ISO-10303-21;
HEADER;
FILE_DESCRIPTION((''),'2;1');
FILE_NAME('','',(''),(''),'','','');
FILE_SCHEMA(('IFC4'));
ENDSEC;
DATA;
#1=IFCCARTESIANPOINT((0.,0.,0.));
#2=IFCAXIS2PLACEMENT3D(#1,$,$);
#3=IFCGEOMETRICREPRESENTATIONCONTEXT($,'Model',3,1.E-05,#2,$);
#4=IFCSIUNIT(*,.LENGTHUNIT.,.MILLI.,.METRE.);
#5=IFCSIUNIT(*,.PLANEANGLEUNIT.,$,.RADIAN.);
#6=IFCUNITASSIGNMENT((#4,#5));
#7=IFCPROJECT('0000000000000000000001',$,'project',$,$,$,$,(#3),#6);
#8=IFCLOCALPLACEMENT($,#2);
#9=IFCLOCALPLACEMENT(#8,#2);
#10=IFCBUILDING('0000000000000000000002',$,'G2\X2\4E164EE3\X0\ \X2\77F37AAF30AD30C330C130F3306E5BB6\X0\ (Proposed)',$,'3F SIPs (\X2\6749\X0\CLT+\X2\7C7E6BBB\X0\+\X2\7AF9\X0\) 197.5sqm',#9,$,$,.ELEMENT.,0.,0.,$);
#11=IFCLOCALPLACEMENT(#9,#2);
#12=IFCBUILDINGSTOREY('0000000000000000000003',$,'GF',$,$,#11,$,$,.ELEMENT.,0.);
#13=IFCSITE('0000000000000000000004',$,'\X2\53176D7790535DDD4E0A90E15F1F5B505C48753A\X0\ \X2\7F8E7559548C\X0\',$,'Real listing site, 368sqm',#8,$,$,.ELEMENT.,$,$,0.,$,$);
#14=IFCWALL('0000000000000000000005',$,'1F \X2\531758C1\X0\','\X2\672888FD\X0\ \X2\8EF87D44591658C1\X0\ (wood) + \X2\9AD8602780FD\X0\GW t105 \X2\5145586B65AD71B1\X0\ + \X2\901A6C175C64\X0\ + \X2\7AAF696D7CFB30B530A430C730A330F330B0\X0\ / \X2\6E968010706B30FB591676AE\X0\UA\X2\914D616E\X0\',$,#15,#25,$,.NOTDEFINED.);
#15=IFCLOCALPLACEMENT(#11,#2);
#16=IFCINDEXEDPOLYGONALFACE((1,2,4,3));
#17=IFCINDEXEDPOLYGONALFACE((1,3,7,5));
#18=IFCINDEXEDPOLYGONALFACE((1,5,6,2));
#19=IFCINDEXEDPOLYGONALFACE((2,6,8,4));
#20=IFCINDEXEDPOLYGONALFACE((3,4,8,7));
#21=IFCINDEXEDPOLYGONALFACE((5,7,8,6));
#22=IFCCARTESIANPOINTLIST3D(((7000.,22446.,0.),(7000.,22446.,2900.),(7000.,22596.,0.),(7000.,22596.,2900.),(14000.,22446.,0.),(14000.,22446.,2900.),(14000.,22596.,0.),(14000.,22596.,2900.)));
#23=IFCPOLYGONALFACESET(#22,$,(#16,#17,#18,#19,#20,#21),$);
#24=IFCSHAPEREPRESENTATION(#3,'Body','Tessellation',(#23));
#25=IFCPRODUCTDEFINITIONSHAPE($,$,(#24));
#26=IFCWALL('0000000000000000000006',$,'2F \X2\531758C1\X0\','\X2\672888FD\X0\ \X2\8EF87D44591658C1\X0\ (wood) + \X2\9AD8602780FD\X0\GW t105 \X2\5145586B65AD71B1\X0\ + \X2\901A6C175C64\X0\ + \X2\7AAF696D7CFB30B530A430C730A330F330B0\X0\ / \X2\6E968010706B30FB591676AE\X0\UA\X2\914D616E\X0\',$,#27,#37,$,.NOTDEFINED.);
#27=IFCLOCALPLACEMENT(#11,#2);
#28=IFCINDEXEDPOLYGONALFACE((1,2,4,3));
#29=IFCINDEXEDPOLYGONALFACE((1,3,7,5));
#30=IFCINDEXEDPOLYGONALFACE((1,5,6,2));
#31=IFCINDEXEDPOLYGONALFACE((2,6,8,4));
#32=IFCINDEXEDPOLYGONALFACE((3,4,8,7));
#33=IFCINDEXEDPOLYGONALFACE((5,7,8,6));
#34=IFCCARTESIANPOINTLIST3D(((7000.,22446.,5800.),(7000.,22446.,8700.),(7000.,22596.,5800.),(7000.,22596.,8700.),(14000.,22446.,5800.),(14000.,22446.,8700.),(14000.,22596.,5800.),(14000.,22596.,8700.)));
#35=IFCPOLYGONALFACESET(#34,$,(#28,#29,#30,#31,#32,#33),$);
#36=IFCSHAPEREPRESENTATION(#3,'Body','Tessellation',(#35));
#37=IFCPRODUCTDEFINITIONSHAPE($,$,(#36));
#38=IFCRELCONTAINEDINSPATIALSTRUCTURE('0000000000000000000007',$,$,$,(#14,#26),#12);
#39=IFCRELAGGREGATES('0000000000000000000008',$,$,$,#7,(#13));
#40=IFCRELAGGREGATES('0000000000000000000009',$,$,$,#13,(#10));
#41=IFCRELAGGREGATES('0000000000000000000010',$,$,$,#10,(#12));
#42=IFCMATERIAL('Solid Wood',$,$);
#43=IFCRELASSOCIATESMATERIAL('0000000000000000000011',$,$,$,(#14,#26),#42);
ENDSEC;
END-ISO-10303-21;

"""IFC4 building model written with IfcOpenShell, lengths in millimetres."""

from ifc_helpers import new_model, si_unit, frame, frame_2d, origin, place, context, project, spatial, rectangle, extrude, material, element, save


model = new_model("IFC4")

# Units and contexts
model_context = context("Model", 3, precision=1e-05, world=origin())
ifc_project = project(units=[si_unit("LENGTHUNIT", "METRE", prefix="MILLI"), si_unit("PLANEANGLEUNIT", "RADIAN")], contexts=[model_context])

# Site, building, storey
site_placement = place(None, origin())
site = spatial("IfcSite", under=ifc_project, at=site_placement, Name="北海道川上郡弟子屈町 美留和", ObjectType="Real listing site, 368sqm", CompositionType="ELEMENT", RefElevation=0.0)
building_placement = place(site_placement, origin())
building = spatial("IfcBuilding", under=site, at=building_placement, Name="G2世代 石窯キッチンの家 (Proposed)", ObjectType="3F SIPs (杉CLT+籾殻+竹) 197.5sqm", CompositionType="ELEMENT", ElevationOfRefHeight=0.0, ElevationOfTerrain=0.0)
storey_placement = place(building_placement, origin())
storey = spatial("IfcBuildingStorey", under=building, at=storey_placement, Name="GF", CompositionType="ELEMENT", Elevation=0.0)

# Shared definitions
ifc_material_1 = material(Name="Solid Wood")

# Wall
wall_1_placement = place(storey_placement, frame((3500.0, 11223.0, 0.0)))
element("IfcWall", 1, at=wall_1_placement, inside=storey, material=ifc_material_1, Name="1F 北壁", Description="木製 軸組外壁 (wood) + 高性能GW t105 充填断熱 + 通気層 + 窯業系サイディング / 準耐火・外皮UA配慮", PredefinedType="NOTDEFINED", context=model_context, shape_type="SweptSolid", body=[
    extrude(rectangle(XDim=7000.0, YDim=150.0, at=frame_2d((3500.0, 75.0))), frame((3500.0, 11223.0, 0.0)), (0.0, 0.0, 1.0), 2900.0),
])

# Wall
wall_2_placement = place(storey_placement, frame((3500.0, 11223.0, 2900.0)))
element("IfcWall", 2, at=wall_2_placement, inside=storey, material=ifc_material_1, Name="2F 北壁", Description="木製 軸組外壁 (wood) + 高性能GW t105 充填断熱 + 通気層 + 窯業系サイディング / 準耐火・外皮UA配慮", PredefinedType="NOTDEFINED", context=model_context, shape_type="SweptSolid", body=[
    extrude(rectangle(XDim=7000.0, YDim=150.0, at=frame_2d((3500.0, 75.0))), frame((3500.0, 11223.0, 2900.0)), (0.0, 0.0, 1.0), 2900.0),
])

save(model, "model.ifc")
